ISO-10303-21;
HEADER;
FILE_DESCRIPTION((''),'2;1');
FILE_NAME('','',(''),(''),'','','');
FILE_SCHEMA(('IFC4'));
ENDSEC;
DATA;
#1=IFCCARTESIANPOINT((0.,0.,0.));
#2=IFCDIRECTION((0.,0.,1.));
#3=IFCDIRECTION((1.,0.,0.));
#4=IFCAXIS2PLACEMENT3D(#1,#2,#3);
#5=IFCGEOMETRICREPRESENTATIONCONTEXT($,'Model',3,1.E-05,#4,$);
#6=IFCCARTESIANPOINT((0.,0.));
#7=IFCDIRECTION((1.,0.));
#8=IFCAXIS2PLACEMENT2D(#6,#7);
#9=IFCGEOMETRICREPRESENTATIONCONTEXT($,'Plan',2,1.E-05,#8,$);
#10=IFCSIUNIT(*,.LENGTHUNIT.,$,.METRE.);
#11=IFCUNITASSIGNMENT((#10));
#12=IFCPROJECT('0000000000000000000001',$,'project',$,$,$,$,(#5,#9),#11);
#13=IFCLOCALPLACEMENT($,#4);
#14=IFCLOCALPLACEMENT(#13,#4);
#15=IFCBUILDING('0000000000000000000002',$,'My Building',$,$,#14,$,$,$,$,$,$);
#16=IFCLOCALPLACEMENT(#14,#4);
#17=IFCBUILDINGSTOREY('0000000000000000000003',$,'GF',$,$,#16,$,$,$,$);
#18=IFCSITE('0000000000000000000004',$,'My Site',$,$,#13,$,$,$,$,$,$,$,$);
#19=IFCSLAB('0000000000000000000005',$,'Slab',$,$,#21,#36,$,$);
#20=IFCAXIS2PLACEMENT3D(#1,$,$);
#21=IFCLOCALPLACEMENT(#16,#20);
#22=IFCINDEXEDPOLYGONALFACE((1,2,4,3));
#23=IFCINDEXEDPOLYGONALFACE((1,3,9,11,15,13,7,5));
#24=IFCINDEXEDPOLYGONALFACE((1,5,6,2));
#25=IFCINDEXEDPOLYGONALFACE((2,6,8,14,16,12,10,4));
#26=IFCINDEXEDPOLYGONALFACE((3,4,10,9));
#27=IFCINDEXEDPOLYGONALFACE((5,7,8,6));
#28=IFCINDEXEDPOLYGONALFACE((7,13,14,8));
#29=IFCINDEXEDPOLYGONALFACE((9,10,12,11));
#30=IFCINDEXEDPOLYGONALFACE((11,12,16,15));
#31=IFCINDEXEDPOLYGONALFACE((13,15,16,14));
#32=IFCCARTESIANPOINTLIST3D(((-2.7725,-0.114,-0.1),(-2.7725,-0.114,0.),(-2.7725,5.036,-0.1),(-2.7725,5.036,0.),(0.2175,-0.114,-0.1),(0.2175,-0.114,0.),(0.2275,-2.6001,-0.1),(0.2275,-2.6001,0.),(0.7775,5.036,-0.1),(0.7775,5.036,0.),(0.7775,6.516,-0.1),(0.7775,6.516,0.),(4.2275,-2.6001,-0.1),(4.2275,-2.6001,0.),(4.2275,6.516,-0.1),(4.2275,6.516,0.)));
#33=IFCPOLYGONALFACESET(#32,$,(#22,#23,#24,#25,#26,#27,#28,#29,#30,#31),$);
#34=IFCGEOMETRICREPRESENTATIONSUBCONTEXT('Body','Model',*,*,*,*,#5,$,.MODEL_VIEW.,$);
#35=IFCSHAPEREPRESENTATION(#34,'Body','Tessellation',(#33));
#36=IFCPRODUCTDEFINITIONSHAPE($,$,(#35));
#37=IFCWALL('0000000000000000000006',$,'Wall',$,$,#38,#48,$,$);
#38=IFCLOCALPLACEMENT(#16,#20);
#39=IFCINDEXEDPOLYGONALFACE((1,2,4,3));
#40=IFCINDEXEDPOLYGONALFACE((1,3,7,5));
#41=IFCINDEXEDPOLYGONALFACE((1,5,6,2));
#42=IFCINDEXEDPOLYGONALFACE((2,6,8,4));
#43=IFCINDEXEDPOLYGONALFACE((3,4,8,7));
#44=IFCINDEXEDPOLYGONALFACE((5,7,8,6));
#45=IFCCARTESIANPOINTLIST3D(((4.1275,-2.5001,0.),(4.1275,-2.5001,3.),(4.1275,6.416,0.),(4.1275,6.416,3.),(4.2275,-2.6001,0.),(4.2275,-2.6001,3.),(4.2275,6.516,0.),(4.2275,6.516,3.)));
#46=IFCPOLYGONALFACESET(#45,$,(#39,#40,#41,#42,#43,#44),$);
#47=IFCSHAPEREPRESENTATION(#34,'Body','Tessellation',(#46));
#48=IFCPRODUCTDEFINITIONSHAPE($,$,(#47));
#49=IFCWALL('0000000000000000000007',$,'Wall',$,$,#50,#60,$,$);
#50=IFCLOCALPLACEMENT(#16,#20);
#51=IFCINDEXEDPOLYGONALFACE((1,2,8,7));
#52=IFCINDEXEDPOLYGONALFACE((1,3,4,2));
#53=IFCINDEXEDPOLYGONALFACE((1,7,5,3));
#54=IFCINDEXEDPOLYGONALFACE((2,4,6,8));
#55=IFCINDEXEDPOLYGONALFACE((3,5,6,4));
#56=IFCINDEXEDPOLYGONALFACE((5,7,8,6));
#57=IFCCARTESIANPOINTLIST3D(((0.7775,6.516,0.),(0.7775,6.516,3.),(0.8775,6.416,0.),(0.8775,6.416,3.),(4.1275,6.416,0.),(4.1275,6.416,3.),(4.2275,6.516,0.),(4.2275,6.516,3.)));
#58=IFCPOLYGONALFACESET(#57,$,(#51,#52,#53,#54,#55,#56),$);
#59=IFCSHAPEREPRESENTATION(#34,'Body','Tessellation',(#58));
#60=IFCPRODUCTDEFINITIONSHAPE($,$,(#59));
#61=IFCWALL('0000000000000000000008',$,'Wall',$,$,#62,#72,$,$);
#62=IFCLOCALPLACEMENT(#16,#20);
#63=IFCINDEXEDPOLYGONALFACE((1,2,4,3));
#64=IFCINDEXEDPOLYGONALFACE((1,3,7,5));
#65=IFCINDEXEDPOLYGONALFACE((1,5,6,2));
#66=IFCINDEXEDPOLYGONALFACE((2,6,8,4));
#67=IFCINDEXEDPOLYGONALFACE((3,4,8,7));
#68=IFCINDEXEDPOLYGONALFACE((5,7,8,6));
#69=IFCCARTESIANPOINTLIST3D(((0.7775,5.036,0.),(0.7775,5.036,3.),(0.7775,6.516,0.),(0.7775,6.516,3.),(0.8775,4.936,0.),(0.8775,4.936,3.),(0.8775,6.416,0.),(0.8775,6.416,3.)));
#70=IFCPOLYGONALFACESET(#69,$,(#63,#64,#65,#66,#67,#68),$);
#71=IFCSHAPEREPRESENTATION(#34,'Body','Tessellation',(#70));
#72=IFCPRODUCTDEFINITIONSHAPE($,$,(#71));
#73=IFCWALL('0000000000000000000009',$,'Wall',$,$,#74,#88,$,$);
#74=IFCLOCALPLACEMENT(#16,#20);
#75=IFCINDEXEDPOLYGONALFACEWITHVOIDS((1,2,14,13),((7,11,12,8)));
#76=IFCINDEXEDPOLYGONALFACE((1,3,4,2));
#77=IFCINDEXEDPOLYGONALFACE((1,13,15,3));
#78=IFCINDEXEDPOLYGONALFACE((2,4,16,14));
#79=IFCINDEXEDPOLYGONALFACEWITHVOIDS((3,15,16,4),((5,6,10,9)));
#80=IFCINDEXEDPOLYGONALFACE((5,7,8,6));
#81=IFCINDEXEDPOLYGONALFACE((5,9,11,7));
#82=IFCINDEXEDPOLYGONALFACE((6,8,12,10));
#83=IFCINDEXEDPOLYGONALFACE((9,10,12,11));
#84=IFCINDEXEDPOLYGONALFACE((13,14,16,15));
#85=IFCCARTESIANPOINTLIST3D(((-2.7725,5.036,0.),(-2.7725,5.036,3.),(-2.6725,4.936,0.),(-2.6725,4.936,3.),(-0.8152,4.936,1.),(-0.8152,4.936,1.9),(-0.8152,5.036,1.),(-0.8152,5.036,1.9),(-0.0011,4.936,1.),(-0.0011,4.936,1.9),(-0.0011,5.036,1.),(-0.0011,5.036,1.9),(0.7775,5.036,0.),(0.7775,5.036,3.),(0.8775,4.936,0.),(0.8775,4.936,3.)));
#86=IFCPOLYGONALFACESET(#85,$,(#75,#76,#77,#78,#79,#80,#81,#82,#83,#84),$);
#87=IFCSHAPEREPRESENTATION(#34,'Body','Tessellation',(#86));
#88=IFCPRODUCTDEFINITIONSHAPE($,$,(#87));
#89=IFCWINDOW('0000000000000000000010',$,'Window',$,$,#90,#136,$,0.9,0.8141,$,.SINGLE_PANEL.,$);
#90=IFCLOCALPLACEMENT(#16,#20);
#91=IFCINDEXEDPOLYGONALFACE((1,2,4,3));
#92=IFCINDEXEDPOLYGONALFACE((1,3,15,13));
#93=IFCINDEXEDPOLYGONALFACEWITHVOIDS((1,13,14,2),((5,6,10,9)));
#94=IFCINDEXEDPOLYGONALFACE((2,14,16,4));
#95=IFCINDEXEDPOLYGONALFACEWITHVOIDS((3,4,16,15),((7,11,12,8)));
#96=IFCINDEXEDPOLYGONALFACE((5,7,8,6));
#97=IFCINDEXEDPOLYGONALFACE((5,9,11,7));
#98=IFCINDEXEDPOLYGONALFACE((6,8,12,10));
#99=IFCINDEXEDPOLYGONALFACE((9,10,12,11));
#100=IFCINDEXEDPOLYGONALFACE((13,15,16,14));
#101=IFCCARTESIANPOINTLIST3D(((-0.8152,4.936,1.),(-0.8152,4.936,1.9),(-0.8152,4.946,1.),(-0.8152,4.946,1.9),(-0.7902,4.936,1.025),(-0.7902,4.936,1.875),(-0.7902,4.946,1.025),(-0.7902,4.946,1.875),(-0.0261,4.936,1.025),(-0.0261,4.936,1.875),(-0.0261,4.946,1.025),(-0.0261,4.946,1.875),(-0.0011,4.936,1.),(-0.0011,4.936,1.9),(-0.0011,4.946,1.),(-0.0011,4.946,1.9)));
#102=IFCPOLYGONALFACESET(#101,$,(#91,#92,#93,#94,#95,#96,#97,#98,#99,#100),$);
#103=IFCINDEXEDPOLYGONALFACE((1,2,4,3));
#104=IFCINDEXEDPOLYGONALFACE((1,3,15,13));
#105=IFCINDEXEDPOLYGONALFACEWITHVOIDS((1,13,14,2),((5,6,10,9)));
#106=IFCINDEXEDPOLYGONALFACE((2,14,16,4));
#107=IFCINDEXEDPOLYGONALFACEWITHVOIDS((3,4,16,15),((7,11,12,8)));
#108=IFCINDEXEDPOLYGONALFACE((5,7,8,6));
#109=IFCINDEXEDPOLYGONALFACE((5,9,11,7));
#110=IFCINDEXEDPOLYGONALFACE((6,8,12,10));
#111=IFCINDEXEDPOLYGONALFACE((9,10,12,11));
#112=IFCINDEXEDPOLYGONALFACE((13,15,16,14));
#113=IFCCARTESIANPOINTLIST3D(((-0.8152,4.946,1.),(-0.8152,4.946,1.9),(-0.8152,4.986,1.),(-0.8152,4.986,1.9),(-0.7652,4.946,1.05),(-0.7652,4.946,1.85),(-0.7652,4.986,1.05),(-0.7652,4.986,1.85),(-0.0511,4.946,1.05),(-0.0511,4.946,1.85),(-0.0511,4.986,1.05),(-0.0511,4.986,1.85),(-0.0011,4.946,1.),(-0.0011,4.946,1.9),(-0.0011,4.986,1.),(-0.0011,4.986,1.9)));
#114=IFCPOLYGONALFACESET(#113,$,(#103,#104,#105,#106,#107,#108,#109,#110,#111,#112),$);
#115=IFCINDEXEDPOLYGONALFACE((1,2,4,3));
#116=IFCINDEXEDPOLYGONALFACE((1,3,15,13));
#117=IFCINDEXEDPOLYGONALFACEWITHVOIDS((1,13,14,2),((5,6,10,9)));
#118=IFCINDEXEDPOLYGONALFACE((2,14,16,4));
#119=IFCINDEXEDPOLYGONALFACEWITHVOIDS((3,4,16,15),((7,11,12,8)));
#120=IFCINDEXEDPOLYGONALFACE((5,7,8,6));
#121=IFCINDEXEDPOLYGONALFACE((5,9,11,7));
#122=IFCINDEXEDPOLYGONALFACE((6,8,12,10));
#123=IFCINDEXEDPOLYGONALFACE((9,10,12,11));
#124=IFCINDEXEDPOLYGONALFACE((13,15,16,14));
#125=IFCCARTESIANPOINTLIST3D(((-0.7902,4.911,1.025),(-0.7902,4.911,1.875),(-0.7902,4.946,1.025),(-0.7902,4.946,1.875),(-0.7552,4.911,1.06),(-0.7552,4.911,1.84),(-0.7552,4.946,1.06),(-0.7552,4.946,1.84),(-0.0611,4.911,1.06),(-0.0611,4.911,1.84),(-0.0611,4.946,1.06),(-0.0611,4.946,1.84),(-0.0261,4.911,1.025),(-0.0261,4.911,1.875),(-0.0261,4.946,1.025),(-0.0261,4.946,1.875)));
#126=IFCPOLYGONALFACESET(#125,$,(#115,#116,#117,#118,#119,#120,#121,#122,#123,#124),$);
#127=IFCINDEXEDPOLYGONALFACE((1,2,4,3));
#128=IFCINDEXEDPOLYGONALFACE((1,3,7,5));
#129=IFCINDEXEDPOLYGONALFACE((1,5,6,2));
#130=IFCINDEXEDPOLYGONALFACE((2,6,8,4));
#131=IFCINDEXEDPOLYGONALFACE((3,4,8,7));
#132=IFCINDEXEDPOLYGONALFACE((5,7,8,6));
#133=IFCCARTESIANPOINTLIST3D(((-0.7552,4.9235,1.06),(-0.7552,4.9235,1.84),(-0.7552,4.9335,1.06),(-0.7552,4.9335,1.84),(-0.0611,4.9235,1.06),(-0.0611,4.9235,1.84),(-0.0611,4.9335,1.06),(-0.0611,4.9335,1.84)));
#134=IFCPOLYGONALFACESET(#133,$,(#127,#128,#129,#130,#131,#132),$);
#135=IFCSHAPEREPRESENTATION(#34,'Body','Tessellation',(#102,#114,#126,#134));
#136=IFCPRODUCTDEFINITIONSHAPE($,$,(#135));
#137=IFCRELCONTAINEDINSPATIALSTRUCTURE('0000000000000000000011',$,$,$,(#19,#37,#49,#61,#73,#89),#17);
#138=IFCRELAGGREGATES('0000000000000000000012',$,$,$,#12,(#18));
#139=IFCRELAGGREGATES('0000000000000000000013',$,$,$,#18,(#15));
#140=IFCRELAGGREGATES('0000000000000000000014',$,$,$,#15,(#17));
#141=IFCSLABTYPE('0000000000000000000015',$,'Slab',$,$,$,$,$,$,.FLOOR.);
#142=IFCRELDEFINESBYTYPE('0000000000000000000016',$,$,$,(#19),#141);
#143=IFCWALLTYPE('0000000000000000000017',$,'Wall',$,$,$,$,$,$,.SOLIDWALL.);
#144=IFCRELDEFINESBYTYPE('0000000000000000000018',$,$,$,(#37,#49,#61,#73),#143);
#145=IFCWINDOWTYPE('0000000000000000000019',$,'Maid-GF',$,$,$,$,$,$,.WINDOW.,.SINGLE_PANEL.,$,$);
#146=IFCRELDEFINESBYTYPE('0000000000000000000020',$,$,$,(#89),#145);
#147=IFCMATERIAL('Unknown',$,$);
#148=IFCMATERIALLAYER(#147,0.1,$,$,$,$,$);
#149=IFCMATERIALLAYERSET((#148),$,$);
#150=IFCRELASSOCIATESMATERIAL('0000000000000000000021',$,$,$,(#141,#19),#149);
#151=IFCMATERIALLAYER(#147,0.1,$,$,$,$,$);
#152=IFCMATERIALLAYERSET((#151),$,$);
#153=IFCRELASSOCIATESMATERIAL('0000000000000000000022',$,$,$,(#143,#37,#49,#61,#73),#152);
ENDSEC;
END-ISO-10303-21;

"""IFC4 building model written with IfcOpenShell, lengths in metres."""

from ifc_helpers import new_model, entity, si_unit, frame, origin_with_axes, origin_2d_with_axis, place, context, subcontext, project, spatial, line, indexed_curve, outline, extrude, shape, source, transform, mapped, material, layer, layer_set, layer_usage, type_object, type_shapes, element, fill, save


model = new_model("IFC4")

# Units and contexts
model_context = context("Model", 3, precision=1e-05, world=origin_with_axes())
plan_context = context("Plan", 2, precision=1e-05, world=origin_2d_with_axis())
body_context_1 = subcontext(model_context, "Body", "Model", "MODEL_VIEW")
body_context_2 = subcontext(plan_context, "Body", "Plan", "PLAN_VIEW")
ifc_project = project(units=[si_unit("LENGTHUNIT", "METRE")], contexts=[model_context, plan_context])

# Site, building, storey
site_placement = place(None, origin_with_axes())
site = spatial("IfcSite", under=ifc_project, at=site_placement, Name="My Site")
building_placement = place(site_placement, origin_with_axes())
building = spatial("IfcBuilding", under=site, at=building_placement, Name="My Building")
storey_placement = place(building_placement, origin_with_axes())
storey = spatial("IfcBuildingStorey", under=building, at=storey_placement, Name="GF")

# Slab
ifc_material = material(Name="Unknown")
ifc_layer_1 = layer(ifc_material, 0.1)
ifc_layer_set_1 = layer_set([ifc_layer_1])
ifc_layer_usage_1 = layer_usage(ifc_layer_set_1, "AXIS3", "POSITIVE", -0.1)
slab_type = type_object("IfcSlabType", Name="Slab", PredefinedType="FLOOR", material=ifc_layer_set_1)
slab_placement = place(storey_placement, frame((4.2275, 6.516, 0.0), z_axis=(0.0, 0.0, 1.0), x_axis=(1.0, 0.0, 0.0)))
element("IfcSlab", 1, at=slab_placement, inside=storey, type_object=slab_type, material=ifc_layer_usage_1, Name="Slab", context=body_context_1, shape_type="SweptSolid", body=[
    extrude(outline(indexed_curve([(0.0, 0.0), (-3.45, 0.0), (-3.45, -1.48), (-7.0, -1.48), (-7.0, -6.63), (-4.01, -6.63), (-4.0, -9.116), (0.0, -9.116), (0.0, 0.0)])), frame((0.0, 0.0, -0.1), z_axis=(0.0, 0.0, 1.0), x_axis=(1.0, 0.0, 0.0)), (0.0, 0.0, 1.0), 0.1),
])

# Shared definitions
ifc_layer_2 = layer(ifc_material, 0.1)
ifc_layer_set_2 = layer_set([ifc_layer_2])
wall_type = type_object("IfcWallType", Name="Wall", PredefinedType="SOLIDWALL", material=ifc_layer_set_2)

# Walls
ifc_layer_usage_2 = layer_usage(ifc_layer_set_2, "AXIS2", "POSITIVE", 0.0)
wall_1_placement = place(storey_placement, frame((4.2275, -2.6001, 0.0), z_axis=(0.0, 0.0, 1.0), x_axis=(0.0, 1.0, 0.0)))
element("IfcWall", 2, at=wall_1_placement, inside=storey, type_object=wall_type, material=ifc_layer_usage_2, Name="Wall", context=body_context_1, shape_type="SweptSolid", body=[
    extrude(outline(indexed_curve([(0.0, 0.0), (0.1, 0.1), (9.016, 0.1), (9.116, 0.0)], segments=[line(1, 2, 3, 4, 1)])), origin_with_axes(), (0.0, 0.0, 1.0), 3.0),
])
ifc_layer_usage_3 = layer_usage(ifc_layer_set_2, "AXIS2", "POSITIVE", 0.0)
wall_2_placement = place(storey_placement, frame((4.2275, 6.516, 0.0), z_axis=(0.0, 0.0, 1.0), x_axis=(-1.0, 0.0, 0.0)))
element("IfcWall", 3, at=wall_2_placement, inside=storey, type_object=wall_type, material=ifc_layer_usage_3, Name="Wall", context=body_context_1, shape_type="SweptSolid", body=[
    extrude(outline(indexed_curve([(0.0, 0.0), (0.1, 0.1), (3.35, 0.1), (3.45, 0.0)], segments=[line(1, 2, 3, 4, 1)])), origin_with_axes(), (0.0, 0.0, 1.0), 3.0),
])
ifc_layer_usage_4 = layer_usage(ifc_layer_set_2, "AXIS2", "POSITIVE", 0.0)
wall_3_placement = place(storey_placement, frame((0.7775, 6.516, 0.0), z_axis=(0.0, 0.0, 1.0), x_axis=(0.0, -1.0, 0.0)))
element("IfcWall", 4, at=wall_3_placement, inside=storey, type_object=wall_type, material=ifc_layer_usage_4, Name="Wall", context=body_context_1, shape_type="SweptSolid", body=[
    extrude(outline(indexed_curve([(0.0, 0.0), (0.1, 0.1), (1.58, 0.1), (1.48, 0.0)], segments=[line(1, 2, 3, 4, 1)])), origin_with_axes(), (0.0, 0.0, 1.0), 3.0),
])

# Wall, opening, window
ifc_layer_usage_5 = layer_usage(ifc_layer_set_2, "AXIS2", "POSITIVE", 0.0)
wall_4_placement = place(storey_placement, frame((0.7775, 5.036, 0.0), z_axis=(0.0, 0.0, 1.0), x_axis=(-1.0, 0.0, 0.0)))
wall_4 = element("IfcWall", 5, at=wall_4_placement, inside=storey, type_object=wall_type, material=ifc_layer_usage_5, Name="Wall", context=body_context_1, shape_type="SweptSolid", body=[
    extrude(outline(indexed_curve([(0.0, 0.0), (-0.1, 0.1), (3.45, 0.1), (3.55, 0.0)], segments=[line(1, 2, 3, 4, 1)])), origin_with_axes(), (0.0, 0.0, 1.0), 3.0),
])
shared_shape_1 = source(origin_with_axes(), body_context_1, "Body", "SweptSolid", [
    extrude(outline(indexed_curve([(0.0, 0.0), (0.8141, 0.0), (0.8141, 0.9), (0.0, 0.9)], segments=[line(1, 2, 3, 4, 1)])), frame((0.0, -0.6, 0.0), z_axis=(0.0, -1.0, 0.0), x_axis=(1.0, 0.0, 0.0)), (0.0, 0.0, -1.0), 1.2),
])
opening_1_placement = place(wall_4_placement, frame((0.7785, 0.0, 1.0), z_axis=(0.0, 0.0, 1.0), x_axis=(1.0, 0.0, 0.0)))
opening_1 = element("IfcOpeningElement", 6, at=opening_1_placement, cuts=wall_4, PredefinedType="OPENING", context=body_context_1, shape_type="MappedRepresentation", body=[
    mapped(shared_shape_1, transform((0.0, 0.0, 0.0), x_axis=(1.0, 0.0, 0.0), y_axis=(0.0, 1.0, 0.0), z_axis=(0.0, 0.0, 1.0), scale=1.0)),
])
window_type_1 = type_object("IfcWindowType", Name="Maid-GF", PartitioningType="SINGLE_PANEL", PredefinedType="WINDOW")
shared_shape_2 = source(origin_with_axes(), body_context_1, "Body", "SweptSolid", [
    extrude(outline(indexed_curve([(0.0, 0.0), (0.8141, 0.0), (0.8141, 0.9), (0.0, 0.9)], segments=[line(1, 2, 3, 4, 1)]), holes=[indexed_curve([(0.025, 0.025), (0.7891, 0.025), (0.7891, 0.875), (0.025, 0.875)], segments=[line(1, 2, 3, 4, 1)])]), frame((0.0, 0.09, 0.0), z_axis=(0.0, -1.0, 0.0), x_axis=(1.0, 0.0, 0.0)), (0.0, 0.0, -1.0), 0.01),
    extrude(outline(indexed_curve([(0.0, 0.0), (0.8141, 0.0), (0.8141, 0.9), (0.0, 0.9)], segments=[line(1, 2, 3, 4, 1)]), holes=[indexed_curve([(0.05, 0.05), (0.7641, 0.05), (0.7641, 0.85), (0.05, 0.85)], segments=[line(1, 2, 3, 4, 1)])]), frame((0.0, 0.05, 0.0), z_axis=(0.0, -1.0, 0.0), x_axis=(1.0, 0.0, 0.0)), (0.0, 0.0, -1.0), 0.04),
    extrude(outline(indexed_curve([(0.0, 0.0), (0.7641, 0.0), (0.7641, 0.85), (0.0, 0.85)], segments=[line(1, 2, 3, 4, 1)]), holes=[indexed_curve([(0.035, 0.035), (0.7291, 0.035), (0.7291, 0.815), (0.035, 0.815)], segments=[line(1, 2, 3, 4, 1)])]), frame((0.025, 0.09, 0.025), z_axis=(0.0, -1.0, 0.0), x_axis=(1.0, 0.0, 0.0)), (0.0, 0.0, -1.0), 0.035),
    extrude(outline(indexed_curve([(0.035, 0.035), (0.7291, 0.035), (0.7291, 0.815), (0.035, 0.815)], segments=[line(1, 2, 3, 4, 1)])), frame((0.025, 0.1025, 0.025), z_axis=(0.0, -1.0, 0.0), x_axis=(1.0, 0.0, 0.0)), (0.0, 0.0, -1.0), 0.01),
])
shared_shape_3 = source(origin_with_axes(), body_context_2, "Body", "Curve2D", [
    entity("IfcIndexedPolyCurve", entity("IfcCartesianPointList2D", [[0.05, 0.05], [0.7641, 0.05]])),
    entity("IfcIndexedPolyCurve", entity("IfcCartesianPointList2D", [[0.0, 0.1], [0.025, 0.1], [0.025, 0.09], [0.05, 0.09], [0.05, 0.05], [0.0, 0.05]]), [entity("IfcLineIndex", [1, 2, 3, 4, 5, 6, 1])]),
    entity("IfcIndexedPolyCurve", entity("IfcCartesianPointList2D", [[0.8141, 0.1], [0.7891, 0.1], [0.7891, 0.09], [0.7641, 0.09], [0.7641, 0.05], [0.8141, 0.05]]), [entity("IfcLineIndex", [1, 2, 3, 4, 5, 6, 1])]),
    entity("IfcIndexedPolyCurve", entity("IfcCartesianPointList2D", [[0.025, 0.09], [0.06, 0.09], [0.06, 0.125], [0.025, 0.125]]), [entity("IfcLineIndex", [1, 2, 3, 4, 1])]),
    entity("IfcIndexedPolyCurve", entity("IfcCartesianPointList2D", [[0.7891, 0.09], [0.7541, 0.09], [0.7541, 0.125], [0.7891, 0.125]]), [entity("IfcLineIndex", [1, 2, 3, 4, 1])]),
    entity("IfcIndexedPolyCurve", entity("IfcCartesianPointList2D", [[0.06, 0.09], [0.7541, 0.09]])),
    entity("IfcIndexedPolyCurve", entity("IfcCartesianPointList2D", [[0.06, 0.125], [0.7541, 0.125]])),
    entity("IfcIndexedPolyCurve", entity("IfcCartesianPointList2D", [[0.06, 0.1075], [0.7541, 0.1075]])),
])
type_shapes(window_type_1, [shared_shape_2, shared_shape_3])
window_1_placement = place(opening_1_placement, frame((0.0, 0.0, 0.0), z_axis=(0.0, 0.0, 1.0), x_axis=(1.0, 0.0, 0.0)))
window_1 = element("IfcWindow", 7, at=window_1_placement, inside=storey, type_object=window_type_1, Name="Window", OverallHeight=0.9, OverallWidth=0.8141, PartitioningType="SINGLE_PANEL", shapes=[
    shape(body_context_1, "Body", "MappedRepresentation", [mapped(shared_shape_2, transform((0.0, 0.0, 0.0), x_axis=(1.0, 0.0, 0.0), y_axis=(0.0, 1.0, 0.0), z_axis=(0.0, 0.0, 1.0), scale=1.0))]),
    shape(body_context_2, "Body", "MappedRepresentation", [mapped(shared_shape_3, transform((0.0, 0.0, 0.0), x_axis=(1.0, 0.0, 0.0), y_axis=(0.0, 1.0, 0.0), z_axis=(0.0, 0.0, 1.0), scale=1.0))]),
])
fill(opening_1, window_1)

save(model, "model.ifc")
